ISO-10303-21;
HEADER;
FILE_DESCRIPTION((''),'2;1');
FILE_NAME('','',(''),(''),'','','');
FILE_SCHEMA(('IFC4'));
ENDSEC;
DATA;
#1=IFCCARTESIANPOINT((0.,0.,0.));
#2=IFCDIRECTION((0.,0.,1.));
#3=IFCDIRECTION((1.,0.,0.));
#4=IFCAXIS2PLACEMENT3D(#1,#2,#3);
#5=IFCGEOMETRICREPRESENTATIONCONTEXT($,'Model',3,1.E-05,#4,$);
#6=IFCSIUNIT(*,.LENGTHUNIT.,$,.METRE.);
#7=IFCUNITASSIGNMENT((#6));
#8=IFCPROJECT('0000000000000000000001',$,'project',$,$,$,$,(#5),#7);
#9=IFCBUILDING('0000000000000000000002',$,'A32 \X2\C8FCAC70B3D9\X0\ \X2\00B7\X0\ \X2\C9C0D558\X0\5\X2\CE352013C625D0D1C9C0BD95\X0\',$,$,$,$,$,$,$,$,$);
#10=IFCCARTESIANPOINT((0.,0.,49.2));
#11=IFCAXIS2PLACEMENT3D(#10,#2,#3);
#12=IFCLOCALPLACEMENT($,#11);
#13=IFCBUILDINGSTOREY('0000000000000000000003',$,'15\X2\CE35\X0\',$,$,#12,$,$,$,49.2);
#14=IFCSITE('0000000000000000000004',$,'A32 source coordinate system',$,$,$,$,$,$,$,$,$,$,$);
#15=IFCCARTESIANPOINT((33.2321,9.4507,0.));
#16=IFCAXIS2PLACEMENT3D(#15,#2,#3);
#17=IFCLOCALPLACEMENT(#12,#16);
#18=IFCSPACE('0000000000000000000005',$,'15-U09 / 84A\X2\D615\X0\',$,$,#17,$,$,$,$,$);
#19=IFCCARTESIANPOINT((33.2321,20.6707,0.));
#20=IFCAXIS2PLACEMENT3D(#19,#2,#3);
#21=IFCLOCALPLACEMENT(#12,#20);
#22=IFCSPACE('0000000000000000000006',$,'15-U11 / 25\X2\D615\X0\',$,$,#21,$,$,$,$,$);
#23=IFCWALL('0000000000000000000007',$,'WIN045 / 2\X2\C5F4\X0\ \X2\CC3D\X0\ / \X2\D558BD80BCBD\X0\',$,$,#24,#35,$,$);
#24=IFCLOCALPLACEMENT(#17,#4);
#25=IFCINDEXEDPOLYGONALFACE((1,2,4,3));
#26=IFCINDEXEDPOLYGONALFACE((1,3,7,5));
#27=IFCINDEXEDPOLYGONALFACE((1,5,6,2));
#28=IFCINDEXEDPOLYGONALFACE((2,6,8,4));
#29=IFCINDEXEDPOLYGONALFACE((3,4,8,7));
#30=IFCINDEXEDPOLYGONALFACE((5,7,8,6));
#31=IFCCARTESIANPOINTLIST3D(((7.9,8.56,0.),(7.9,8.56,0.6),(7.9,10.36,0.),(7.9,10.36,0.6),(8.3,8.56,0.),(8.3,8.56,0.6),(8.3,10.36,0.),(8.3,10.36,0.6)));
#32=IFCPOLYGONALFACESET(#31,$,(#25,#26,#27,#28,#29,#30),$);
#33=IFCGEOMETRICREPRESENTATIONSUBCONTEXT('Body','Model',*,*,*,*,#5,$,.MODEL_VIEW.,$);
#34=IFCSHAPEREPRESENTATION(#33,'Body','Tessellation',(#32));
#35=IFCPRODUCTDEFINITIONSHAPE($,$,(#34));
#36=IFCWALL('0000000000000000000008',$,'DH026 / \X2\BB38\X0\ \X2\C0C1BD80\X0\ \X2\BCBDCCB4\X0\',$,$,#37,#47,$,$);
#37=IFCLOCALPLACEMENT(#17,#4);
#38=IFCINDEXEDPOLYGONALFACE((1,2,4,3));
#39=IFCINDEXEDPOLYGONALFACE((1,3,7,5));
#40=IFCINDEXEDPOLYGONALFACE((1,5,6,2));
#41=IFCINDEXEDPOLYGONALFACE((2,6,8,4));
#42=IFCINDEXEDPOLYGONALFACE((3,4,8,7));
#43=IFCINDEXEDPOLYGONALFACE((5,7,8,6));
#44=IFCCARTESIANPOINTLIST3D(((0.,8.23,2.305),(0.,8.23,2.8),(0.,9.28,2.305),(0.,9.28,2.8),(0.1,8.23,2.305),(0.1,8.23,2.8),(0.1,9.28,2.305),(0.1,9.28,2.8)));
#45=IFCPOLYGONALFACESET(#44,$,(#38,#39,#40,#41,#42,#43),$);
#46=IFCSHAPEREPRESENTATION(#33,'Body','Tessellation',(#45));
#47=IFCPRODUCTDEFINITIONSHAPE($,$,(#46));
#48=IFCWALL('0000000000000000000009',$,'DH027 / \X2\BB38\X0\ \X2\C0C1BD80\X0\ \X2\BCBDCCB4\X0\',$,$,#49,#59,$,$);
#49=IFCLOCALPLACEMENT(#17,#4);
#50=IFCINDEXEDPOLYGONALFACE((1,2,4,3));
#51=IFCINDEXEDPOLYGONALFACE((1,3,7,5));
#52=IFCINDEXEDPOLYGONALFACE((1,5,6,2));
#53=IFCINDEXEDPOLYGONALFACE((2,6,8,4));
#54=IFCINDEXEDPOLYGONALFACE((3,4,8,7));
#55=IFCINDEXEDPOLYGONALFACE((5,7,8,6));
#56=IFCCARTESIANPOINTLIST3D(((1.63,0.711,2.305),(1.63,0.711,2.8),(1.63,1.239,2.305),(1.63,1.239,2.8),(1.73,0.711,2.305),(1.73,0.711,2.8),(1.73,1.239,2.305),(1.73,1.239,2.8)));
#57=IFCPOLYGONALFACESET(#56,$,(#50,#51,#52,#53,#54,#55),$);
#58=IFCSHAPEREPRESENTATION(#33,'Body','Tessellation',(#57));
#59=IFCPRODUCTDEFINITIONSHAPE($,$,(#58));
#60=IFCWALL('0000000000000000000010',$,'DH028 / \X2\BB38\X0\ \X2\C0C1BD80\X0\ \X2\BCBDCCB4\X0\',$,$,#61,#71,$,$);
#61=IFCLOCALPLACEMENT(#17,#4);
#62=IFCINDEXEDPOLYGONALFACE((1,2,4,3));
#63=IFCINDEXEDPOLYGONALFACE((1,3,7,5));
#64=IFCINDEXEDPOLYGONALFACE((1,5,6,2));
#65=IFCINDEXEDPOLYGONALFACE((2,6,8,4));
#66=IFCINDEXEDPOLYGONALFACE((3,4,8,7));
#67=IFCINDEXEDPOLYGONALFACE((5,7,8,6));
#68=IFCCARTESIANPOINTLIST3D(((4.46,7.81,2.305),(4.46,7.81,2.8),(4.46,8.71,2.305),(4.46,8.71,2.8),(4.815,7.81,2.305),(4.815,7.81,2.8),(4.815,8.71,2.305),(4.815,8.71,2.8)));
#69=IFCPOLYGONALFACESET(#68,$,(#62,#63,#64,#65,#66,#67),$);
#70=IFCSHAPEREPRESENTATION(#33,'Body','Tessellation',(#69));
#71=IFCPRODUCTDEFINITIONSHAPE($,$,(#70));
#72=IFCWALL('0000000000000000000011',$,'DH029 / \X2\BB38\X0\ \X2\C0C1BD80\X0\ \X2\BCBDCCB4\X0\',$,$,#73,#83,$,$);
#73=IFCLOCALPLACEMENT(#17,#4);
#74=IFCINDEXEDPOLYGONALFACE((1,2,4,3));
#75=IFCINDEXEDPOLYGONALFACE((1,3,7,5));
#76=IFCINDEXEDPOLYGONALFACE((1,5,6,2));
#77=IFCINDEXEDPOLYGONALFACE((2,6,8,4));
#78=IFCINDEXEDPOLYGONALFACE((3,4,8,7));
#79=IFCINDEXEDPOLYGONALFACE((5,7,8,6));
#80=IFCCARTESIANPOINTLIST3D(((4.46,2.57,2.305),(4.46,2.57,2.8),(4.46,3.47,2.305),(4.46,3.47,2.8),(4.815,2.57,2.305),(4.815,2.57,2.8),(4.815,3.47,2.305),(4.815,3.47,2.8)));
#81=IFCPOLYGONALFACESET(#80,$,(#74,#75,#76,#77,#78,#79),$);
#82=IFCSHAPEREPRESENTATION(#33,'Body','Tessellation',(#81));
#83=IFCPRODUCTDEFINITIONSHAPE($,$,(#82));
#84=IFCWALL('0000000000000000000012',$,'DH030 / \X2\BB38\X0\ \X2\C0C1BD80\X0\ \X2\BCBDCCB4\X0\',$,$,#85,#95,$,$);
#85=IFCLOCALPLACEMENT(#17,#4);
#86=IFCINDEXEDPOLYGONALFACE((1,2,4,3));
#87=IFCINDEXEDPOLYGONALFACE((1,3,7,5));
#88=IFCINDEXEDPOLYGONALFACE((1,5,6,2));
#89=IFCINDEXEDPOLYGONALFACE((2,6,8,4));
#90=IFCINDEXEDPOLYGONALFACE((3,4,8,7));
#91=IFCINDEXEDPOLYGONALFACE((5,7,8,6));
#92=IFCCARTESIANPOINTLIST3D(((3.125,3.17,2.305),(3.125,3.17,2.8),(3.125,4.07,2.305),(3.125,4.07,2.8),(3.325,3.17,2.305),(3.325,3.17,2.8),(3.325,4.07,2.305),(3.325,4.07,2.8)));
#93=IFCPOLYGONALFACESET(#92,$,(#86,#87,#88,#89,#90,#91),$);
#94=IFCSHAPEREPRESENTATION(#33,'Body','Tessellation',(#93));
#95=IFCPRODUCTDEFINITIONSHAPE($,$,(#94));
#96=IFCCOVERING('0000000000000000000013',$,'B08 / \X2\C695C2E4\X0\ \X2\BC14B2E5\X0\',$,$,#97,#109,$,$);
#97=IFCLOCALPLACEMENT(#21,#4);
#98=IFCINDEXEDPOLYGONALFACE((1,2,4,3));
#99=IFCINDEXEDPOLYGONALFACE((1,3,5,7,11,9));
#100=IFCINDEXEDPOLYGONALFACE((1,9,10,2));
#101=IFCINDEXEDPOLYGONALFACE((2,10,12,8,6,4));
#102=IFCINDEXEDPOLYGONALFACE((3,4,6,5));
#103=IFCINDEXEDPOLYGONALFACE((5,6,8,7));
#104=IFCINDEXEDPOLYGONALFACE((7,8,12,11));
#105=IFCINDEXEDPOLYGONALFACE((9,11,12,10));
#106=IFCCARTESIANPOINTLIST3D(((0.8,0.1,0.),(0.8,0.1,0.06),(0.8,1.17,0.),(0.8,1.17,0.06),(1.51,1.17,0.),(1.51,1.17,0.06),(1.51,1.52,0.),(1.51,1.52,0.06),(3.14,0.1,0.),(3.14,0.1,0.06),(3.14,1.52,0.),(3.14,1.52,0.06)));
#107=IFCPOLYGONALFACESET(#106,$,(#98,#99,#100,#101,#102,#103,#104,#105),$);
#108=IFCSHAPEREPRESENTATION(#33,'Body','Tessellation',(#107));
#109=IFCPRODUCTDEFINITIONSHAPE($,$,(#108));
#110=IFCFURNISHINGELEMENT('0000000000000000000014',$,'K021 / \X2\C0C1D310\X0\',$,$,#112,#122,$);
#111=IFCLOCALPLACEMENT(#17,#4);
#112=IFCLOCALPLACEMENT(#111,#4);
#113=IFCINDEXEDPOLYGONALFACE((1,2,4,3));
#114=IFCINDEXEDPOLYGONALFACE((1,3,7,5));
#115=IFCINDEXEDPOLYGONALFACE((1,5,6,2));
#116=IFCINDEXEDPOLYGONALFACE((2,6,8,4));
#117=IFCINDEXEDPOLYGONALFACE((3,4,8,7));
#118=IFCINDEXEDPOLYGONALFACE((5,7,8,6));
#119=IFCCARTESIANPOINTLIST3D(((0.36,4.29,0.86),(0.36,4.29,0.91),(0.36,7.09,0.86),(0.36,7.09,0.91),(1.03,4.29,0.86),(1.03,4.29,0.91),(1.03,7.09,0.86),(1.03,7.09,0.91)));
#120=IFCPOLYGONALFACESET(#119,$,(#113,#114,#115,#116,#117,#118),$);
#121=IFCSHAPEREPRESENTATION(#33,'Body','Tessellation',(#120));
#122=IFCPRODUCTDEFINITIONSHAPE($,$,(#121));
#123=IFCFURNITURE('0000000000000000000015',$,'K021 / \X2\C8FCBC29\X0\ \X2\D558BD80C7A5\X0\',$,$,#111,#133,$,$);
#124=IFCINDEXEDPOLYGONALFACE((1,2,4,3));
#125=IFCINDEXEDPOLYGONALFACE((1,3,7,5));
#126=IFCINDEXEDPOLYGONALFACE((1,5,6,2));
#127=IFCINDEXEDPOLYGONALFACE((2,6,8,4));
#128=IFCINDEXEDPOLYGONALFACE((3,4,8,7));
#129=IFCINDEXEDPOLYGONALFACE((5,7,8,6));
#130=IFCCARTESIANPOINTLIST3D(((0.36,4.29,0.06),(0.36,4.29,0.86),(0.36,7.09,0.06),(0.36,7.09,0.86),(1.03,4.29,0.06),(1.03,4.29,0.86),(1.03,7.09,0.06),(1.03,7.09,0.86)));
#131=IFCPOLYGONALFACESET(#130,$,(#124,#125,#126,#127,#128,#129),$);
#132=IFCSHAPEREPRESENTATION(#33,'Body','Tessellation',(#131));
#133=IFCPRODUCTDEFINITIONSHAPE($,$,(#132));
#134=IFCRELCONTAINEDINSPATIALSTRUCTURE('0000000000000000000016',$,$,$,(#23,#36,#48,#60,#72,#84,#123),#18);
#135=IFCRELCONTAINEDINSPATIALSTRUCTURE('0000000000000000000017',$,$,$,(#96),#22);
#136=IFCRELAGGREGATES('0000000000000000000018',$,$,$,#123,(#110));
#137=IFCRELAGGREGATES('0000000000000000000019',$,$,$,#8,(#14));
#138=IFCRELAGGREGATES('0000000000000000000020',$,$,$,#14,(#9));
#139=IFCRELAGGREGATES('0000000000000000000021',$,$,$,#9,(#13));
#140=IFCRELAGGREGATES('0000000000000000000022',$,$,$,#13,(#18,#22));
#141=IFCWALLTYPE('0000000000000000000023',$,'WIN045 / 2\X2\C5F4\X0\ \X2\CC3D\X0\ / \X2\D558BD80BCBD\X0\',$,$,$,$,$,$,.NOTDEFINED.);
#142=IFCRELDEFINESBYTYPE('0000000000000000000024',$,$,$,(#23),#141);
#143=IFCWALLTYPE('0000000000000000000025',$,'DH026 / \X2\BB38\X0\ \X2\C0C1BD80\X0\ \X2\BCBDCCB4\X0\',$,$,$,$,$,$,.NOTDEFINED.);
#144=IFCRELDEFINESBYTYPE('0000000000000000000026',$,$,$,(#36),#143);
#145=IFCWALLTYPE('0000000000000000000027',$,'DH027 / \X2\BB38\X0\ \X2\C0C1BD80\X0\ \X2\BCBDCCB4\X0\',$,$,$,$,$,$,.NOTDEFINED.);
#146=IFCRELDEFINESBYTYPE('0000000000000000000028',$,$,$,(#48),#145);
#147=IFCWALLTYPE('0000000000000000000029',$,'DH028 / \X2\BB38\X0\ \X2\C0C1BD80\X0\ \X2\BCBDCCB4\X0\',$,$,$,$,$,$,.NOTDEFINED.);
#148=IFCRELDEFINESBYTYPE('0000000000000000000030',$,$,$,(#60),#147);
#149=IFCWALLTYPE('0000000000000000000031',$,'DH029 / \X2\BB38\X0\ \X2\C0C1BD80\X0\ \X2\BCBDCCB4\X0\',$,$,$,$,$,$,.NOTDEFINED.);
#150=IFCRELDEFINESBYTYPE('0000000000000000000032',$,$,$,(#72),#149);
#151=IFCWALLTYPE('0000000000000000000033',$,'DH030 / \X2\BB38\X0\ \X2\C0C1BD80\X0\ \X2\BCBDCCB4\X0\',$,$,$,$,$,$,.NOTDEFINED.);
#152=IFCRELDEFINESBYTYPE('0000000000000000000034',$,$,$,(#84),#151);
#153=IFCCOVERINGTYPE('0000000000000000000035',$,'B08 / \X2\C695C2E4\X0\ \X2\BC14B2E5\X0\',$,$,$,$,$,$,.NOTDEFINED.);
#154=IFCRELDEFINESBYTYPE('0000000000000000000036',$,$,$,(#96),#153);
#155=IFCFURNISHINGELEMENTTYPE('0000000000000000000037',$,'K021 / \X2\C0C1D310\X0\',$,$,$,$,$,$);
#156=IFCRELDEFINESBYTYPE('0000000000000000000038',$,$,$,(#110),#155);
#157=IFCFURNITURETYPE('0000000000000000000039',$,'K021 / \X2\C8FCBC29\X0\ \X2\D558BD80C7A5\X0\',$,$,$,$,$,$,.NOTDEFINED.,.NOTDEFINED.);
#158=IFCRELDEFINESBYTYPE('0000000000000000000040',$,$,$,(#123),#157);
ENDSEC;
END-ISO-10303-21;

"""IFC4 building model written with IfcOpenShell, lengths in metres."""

from ifc_helpers import new_model, si_unit, frame, origin, origin_with_axes, place, context, subcontext, project, spatial, polyline, outline, extrude, source, transform, mapped, type_object, type_shapes, element, aggregate, save


model = new_model("IFC4")

# Units and contexts
model_context = context("Model", 3, precision=1e-05, world=origin_with_axes())
body_context = subcontext(model_context, "Body", "Model", "MODEL_VIEW")
ifc_project = project(units=[si_unit("LENGTHUNIT", "METRE")], contexts=[model_context])

# Site, building, storey, space
site = spatial("IfcSite", under=ifc_project, Name="A32 source coordinate system")
building = spatial("IfcBuilding", under=site, Name="A32 주거동 · 지하5층–옥탑지붕")
storey_placement = place(None, frame((0.0, 0.0, 49.2), z_axis=(0.0, 0.0, 1.0), x_axis=(1.0, 0.0, 0.0)))
storey = spatial("IfcBuildingStorey", under=building, at=storey_placement, Name="15층", Elevation=49.2)
space_1_placement = place(storey_placement, frame((33.2321, 9.4507, 0.0), z_axis=(0.0, 0.0, 1.0), x_axis=(1.0, 0.0, 0.0)))
space_1 = spatial("IfcSpace", under=storey, at=space_1_placement, Name="15-U09 / 84A형")

# Walls
wall_type_1 = type_object("IfcWallType", Name="WIN045 / 2열 창 / 하부벽", PredefinedType="NOTDEFINED")
shared_shape_1 = source(origin(), body_context, "Body", "SweptSolid", [
    extrude(outline(polyline([(7.9, 10.36), (8.3, 10.36), (8.3, 8.56), (7.9, 8.56), (7.9, 10.36)])), origin(), (0.0, 0.0, 1.0), 0.6),
])
type_shapes(wall_type_1, [shared_shape_1])
wall_1_placement = place(space_1_placement, origin_with_axes())
element("IfcWall", 1, at=wall_1_placement, inside=space_1, type_object=wall_type_1, Name="WIN045 / 2열 창 / 하부벽", context=body_context, shape_type="MappedRepresentation", body=[
    mapped(shared_shape_1, transform((0.0, 0.0, 0.0), scale=1.0)),
])
wall_type_2 = type_object("IfcWallType", Name="DH026 / 문 상부 벽체", PredefinedType="NOTDEFINED")
shared_shape_2 = source(origin(), body_context, "Body", "SweptSolid", [
    extrude(outline(polyline([(0.1, 9.28), (0.1, 8.23), (0.0, 8.23), (0.0, 9.28), (0.1, 9.28)])), frame((0.0, 0.0, 2.305)), (0.0, 0.0, 1.0), 0.495),
])
type_shapes(wall_type_2, [shared_shape_2])
wall_2_placement = place(space_1_placement, origin_with_axes())
element("IfcWall", 2, at=wall_2_placement, inside=space_1, type_object=wall_type_2, Name="DH026 / 문 상부 벽체", context=body_context, shape_type="MappedRepresentation", body=[
    mapped(shared_shape_2, transform((0.0, 0.0, 0.0), scale=1.0)),
])
wall_type_3 = type_object("IfcWallType", Name="DH027 / 문 상부 벽체", PredefinedType="NOTDEFINED")
shared_shape_3 = source(origin(), body_context, "Body", "SweptSolid", [
    extrude(outline(polyline([(1.63, 1.239), (1.73, 1.239), (1.73, 0.711), (1.63, 0.711), (1.63, 1.239)])), frame((0.0, 0.0, 2.305)), (0.0, 0.0, 1.0), 0.495),
])
type_shapes(wall_type_3, [shared_shape_3])
wall_3_placement = place(space_1_placement, origin_with_axes())
element("IfcWall", 3, at=wall_3_placement, inside=space_1, type_object=wall_type_3, Name="DH027 / 문 상부 벽체", context=body_context, shape_type="MappedRepresentation", body=[
    mapped(shared_shape_3, transform((0.0, 0.0, 0.0), scale=1.0)),
])
wall_type_4 = type_object("IfcWallType", Name="DH028 / 문 상부 벽체", PredefinedType="NOTDEFINED")
shared_shape_4 = source(origin(), body_context, "Body", "SweptSolid", [
    extrude(outline(polyline([(4.815, 8.71), (4.815, 7.81), (4.46, 7.81), (4.46, 8.71), (4.815, 8.71)])), frame((0.0, 0.0, 2.305)), (0.0, 0.0, 1.0), 0.495),
])
type_shapes(wall_type_4, [shared_shape_4])
wall_4_placement = place(space_1_placement, origin_with_axes())
element("IfcWall", 4, at=wall_4_placement, inside=space_1, type_object=wall_type_4, Name="DH028 / 문 상부 벽체", context=body_context, shape_type="MappedRepresentation", body=[
    mapped(shared_shape_4, transform((0.0, 0.0, 0.0), scale=1.0)),
])
wall_type_5 = type_object("IfcWallType", Name="DH029 / 문 상부 벽체", PredefinedType="NOTDEFINED")
shared_shape_5 = source(origin(), body_context, "Body", "SweptSolid", [
    extrude(outline(polyline([(4.815, 3.47), (4.815, 2.57), (4.46, 2.57), (4.46, 3.47), (4.815, 3.47)])), frame((0.0, 0.0, 2.305)), (0.0, 0.0, 1.0), 0.495),
])
type_shapes(wall_type_5, [shared_shape_5])
wall_5_placement = place(space_1_placement, origin_with_axes())
element("IfcWall", 5, at=wall_5_placement, inside=space_1, type_object=wall_type_5, Name="DH029 / 문 상부 벽체", context=body_context, shape_type="MappedRepresentation", body=[
    mapped(shared_shape_5, transform((0.0, 0.0, 0.0), scale=1.0)),
])
wall_type_6 = type_object("IfcWallType", Name="DH030 / 문 상부 벽체", PredefinedType="NOTDEFINED")
shared_shape_6 = source(origin(), body_context, "Body", "SweptSolid", [
    extrude(outline(polyline([(3.325, 4.07), (3.325, 3.17), (3.125, 3.17), (3.125, 4.07), (3.325, 4.07)])), frame((0.0, 0.0, 2.305)), (0.0, 0.0, 1.0), 0.495),
])
type_shapes(wall_type_6, [shared_shape_6])
wall_6_placement = place(space_1_placement, origin_with_axes())
element("IfcWall", 6, at=wall_6_placement, inside=space_1, type_object=wall_type_6, Name="DH030 / 문 상부 벽체", context=body_context, shape_type="MappedRepresentation", body=[
    mapped(shared_shape_6, transform((0.0, 0.0, 0.0), scale=1.0)),
])

# Shared definitions
space_2_placement = place(storey_placement, frame((33.2321, 20.6707, 0.0), z_axis=(0.0, 0.0, 1.0), x_axis=(1.0, 0.0, 0.0)))
space_2 = spatial("IfcSpace", under=storey, at=space_2_placement, Name="15-U11 / 25형")

# Covering
covering_type_1 = type_object("IfcCoveringType", Name="B08 / 욕실 바닥", PredefinedType="NOTDEFINED")
shared_shape_7 = source(origin(), body_context, "Body", "SweptSolid", [
    extrude(outline(polyline([(3.14, 0.1), (0.8, 0.1), (0.8, 1.17), (1.51, 1.17), (1.51, 1.52), (3.14, 1.52), (3.14, 0.1)])), origin(), (0.0, 0.0, 1.0), 0.06),
])
type_shapes(covering_type_1, [shared_shape_7])
covering_1_placement = place(space_2_placement, origin_with_axes())
element("IfcCovering", 7, at=covering_1_placement, inside=space_2, type_object=covering_type_1, Name="B08 / 욕실 바닥", context=body_context, shape_type="MappedRepresentation", body=[
    mapped(shared_shape_7, transform((0.0, 0.0, 0.0), scale=1.0)),
])

# Furnishing element
furnishing_element_type = type_object("IfcFurnishingElementType", Name="K021 / 상판")
shared_shape_8 = source(origin(), body_context, "Body", "SweptSolid", [
    extrude(outline(polyline([(0.36, 7.09), (1.03, 7.09), (1.03, 4.29), (0.36, 4.29), (0.36, 7.09)])), frame((0.0, 0.0, 0.86)), (0.0, 0.0, 1.0), 0.05),
])
type_shapes(furnishing_element_type, [shared_shape_8])
furniture_placement = place(space_1_placement, origin_with_axes())
furnishing_placement = place(furniture_placement, origin_with_axes())
furnishing = element("IfcFurnishingElement", 8, at=furnishing_placement, type_object=furnishing_element_type, Name="K021 / 상판", context=body_context, shape_type="MappedRepresentation", body=[
    mapped(shared_shape_8, transform((0.0, 0.0, 0.0), scale=1.0)),
])

# Furniture
furniture_type = type_object("IfcFurnitureType", Name="K021 / 주방 하부장", AssemblyPlace="NOTDEFINED", PredefinedType="NOTDEFINED")
shared_shape_9 = source(origin(), body_context, "Body", "SweptSolid", [
    extrude(outline(polyline([(0.36, 4.29), (0.36, 7.09), (1.03, 7.09), (1.03, 4.29), (0.36, 4.29)])), frame((0.0, 0.0, 0.06)), (0.0, 0.0, 1.0), 0.8),
])
type_shapes(furniture_type, [shared_shape_9])
furniture = element("IfcFurniture", 9, at=furniture_placement, inside=space_1, type_object=furniture_type, Name="K021 / 주방 하부장", context=body_context, shape_type="MappedRepresentation", body=[
    mapped(shared_shape_9, transform((0.0, 0.0, 0.0), scale=1.0)),
])
aggregate(furniture, [furnishing])

save(model, "model.ifc")
